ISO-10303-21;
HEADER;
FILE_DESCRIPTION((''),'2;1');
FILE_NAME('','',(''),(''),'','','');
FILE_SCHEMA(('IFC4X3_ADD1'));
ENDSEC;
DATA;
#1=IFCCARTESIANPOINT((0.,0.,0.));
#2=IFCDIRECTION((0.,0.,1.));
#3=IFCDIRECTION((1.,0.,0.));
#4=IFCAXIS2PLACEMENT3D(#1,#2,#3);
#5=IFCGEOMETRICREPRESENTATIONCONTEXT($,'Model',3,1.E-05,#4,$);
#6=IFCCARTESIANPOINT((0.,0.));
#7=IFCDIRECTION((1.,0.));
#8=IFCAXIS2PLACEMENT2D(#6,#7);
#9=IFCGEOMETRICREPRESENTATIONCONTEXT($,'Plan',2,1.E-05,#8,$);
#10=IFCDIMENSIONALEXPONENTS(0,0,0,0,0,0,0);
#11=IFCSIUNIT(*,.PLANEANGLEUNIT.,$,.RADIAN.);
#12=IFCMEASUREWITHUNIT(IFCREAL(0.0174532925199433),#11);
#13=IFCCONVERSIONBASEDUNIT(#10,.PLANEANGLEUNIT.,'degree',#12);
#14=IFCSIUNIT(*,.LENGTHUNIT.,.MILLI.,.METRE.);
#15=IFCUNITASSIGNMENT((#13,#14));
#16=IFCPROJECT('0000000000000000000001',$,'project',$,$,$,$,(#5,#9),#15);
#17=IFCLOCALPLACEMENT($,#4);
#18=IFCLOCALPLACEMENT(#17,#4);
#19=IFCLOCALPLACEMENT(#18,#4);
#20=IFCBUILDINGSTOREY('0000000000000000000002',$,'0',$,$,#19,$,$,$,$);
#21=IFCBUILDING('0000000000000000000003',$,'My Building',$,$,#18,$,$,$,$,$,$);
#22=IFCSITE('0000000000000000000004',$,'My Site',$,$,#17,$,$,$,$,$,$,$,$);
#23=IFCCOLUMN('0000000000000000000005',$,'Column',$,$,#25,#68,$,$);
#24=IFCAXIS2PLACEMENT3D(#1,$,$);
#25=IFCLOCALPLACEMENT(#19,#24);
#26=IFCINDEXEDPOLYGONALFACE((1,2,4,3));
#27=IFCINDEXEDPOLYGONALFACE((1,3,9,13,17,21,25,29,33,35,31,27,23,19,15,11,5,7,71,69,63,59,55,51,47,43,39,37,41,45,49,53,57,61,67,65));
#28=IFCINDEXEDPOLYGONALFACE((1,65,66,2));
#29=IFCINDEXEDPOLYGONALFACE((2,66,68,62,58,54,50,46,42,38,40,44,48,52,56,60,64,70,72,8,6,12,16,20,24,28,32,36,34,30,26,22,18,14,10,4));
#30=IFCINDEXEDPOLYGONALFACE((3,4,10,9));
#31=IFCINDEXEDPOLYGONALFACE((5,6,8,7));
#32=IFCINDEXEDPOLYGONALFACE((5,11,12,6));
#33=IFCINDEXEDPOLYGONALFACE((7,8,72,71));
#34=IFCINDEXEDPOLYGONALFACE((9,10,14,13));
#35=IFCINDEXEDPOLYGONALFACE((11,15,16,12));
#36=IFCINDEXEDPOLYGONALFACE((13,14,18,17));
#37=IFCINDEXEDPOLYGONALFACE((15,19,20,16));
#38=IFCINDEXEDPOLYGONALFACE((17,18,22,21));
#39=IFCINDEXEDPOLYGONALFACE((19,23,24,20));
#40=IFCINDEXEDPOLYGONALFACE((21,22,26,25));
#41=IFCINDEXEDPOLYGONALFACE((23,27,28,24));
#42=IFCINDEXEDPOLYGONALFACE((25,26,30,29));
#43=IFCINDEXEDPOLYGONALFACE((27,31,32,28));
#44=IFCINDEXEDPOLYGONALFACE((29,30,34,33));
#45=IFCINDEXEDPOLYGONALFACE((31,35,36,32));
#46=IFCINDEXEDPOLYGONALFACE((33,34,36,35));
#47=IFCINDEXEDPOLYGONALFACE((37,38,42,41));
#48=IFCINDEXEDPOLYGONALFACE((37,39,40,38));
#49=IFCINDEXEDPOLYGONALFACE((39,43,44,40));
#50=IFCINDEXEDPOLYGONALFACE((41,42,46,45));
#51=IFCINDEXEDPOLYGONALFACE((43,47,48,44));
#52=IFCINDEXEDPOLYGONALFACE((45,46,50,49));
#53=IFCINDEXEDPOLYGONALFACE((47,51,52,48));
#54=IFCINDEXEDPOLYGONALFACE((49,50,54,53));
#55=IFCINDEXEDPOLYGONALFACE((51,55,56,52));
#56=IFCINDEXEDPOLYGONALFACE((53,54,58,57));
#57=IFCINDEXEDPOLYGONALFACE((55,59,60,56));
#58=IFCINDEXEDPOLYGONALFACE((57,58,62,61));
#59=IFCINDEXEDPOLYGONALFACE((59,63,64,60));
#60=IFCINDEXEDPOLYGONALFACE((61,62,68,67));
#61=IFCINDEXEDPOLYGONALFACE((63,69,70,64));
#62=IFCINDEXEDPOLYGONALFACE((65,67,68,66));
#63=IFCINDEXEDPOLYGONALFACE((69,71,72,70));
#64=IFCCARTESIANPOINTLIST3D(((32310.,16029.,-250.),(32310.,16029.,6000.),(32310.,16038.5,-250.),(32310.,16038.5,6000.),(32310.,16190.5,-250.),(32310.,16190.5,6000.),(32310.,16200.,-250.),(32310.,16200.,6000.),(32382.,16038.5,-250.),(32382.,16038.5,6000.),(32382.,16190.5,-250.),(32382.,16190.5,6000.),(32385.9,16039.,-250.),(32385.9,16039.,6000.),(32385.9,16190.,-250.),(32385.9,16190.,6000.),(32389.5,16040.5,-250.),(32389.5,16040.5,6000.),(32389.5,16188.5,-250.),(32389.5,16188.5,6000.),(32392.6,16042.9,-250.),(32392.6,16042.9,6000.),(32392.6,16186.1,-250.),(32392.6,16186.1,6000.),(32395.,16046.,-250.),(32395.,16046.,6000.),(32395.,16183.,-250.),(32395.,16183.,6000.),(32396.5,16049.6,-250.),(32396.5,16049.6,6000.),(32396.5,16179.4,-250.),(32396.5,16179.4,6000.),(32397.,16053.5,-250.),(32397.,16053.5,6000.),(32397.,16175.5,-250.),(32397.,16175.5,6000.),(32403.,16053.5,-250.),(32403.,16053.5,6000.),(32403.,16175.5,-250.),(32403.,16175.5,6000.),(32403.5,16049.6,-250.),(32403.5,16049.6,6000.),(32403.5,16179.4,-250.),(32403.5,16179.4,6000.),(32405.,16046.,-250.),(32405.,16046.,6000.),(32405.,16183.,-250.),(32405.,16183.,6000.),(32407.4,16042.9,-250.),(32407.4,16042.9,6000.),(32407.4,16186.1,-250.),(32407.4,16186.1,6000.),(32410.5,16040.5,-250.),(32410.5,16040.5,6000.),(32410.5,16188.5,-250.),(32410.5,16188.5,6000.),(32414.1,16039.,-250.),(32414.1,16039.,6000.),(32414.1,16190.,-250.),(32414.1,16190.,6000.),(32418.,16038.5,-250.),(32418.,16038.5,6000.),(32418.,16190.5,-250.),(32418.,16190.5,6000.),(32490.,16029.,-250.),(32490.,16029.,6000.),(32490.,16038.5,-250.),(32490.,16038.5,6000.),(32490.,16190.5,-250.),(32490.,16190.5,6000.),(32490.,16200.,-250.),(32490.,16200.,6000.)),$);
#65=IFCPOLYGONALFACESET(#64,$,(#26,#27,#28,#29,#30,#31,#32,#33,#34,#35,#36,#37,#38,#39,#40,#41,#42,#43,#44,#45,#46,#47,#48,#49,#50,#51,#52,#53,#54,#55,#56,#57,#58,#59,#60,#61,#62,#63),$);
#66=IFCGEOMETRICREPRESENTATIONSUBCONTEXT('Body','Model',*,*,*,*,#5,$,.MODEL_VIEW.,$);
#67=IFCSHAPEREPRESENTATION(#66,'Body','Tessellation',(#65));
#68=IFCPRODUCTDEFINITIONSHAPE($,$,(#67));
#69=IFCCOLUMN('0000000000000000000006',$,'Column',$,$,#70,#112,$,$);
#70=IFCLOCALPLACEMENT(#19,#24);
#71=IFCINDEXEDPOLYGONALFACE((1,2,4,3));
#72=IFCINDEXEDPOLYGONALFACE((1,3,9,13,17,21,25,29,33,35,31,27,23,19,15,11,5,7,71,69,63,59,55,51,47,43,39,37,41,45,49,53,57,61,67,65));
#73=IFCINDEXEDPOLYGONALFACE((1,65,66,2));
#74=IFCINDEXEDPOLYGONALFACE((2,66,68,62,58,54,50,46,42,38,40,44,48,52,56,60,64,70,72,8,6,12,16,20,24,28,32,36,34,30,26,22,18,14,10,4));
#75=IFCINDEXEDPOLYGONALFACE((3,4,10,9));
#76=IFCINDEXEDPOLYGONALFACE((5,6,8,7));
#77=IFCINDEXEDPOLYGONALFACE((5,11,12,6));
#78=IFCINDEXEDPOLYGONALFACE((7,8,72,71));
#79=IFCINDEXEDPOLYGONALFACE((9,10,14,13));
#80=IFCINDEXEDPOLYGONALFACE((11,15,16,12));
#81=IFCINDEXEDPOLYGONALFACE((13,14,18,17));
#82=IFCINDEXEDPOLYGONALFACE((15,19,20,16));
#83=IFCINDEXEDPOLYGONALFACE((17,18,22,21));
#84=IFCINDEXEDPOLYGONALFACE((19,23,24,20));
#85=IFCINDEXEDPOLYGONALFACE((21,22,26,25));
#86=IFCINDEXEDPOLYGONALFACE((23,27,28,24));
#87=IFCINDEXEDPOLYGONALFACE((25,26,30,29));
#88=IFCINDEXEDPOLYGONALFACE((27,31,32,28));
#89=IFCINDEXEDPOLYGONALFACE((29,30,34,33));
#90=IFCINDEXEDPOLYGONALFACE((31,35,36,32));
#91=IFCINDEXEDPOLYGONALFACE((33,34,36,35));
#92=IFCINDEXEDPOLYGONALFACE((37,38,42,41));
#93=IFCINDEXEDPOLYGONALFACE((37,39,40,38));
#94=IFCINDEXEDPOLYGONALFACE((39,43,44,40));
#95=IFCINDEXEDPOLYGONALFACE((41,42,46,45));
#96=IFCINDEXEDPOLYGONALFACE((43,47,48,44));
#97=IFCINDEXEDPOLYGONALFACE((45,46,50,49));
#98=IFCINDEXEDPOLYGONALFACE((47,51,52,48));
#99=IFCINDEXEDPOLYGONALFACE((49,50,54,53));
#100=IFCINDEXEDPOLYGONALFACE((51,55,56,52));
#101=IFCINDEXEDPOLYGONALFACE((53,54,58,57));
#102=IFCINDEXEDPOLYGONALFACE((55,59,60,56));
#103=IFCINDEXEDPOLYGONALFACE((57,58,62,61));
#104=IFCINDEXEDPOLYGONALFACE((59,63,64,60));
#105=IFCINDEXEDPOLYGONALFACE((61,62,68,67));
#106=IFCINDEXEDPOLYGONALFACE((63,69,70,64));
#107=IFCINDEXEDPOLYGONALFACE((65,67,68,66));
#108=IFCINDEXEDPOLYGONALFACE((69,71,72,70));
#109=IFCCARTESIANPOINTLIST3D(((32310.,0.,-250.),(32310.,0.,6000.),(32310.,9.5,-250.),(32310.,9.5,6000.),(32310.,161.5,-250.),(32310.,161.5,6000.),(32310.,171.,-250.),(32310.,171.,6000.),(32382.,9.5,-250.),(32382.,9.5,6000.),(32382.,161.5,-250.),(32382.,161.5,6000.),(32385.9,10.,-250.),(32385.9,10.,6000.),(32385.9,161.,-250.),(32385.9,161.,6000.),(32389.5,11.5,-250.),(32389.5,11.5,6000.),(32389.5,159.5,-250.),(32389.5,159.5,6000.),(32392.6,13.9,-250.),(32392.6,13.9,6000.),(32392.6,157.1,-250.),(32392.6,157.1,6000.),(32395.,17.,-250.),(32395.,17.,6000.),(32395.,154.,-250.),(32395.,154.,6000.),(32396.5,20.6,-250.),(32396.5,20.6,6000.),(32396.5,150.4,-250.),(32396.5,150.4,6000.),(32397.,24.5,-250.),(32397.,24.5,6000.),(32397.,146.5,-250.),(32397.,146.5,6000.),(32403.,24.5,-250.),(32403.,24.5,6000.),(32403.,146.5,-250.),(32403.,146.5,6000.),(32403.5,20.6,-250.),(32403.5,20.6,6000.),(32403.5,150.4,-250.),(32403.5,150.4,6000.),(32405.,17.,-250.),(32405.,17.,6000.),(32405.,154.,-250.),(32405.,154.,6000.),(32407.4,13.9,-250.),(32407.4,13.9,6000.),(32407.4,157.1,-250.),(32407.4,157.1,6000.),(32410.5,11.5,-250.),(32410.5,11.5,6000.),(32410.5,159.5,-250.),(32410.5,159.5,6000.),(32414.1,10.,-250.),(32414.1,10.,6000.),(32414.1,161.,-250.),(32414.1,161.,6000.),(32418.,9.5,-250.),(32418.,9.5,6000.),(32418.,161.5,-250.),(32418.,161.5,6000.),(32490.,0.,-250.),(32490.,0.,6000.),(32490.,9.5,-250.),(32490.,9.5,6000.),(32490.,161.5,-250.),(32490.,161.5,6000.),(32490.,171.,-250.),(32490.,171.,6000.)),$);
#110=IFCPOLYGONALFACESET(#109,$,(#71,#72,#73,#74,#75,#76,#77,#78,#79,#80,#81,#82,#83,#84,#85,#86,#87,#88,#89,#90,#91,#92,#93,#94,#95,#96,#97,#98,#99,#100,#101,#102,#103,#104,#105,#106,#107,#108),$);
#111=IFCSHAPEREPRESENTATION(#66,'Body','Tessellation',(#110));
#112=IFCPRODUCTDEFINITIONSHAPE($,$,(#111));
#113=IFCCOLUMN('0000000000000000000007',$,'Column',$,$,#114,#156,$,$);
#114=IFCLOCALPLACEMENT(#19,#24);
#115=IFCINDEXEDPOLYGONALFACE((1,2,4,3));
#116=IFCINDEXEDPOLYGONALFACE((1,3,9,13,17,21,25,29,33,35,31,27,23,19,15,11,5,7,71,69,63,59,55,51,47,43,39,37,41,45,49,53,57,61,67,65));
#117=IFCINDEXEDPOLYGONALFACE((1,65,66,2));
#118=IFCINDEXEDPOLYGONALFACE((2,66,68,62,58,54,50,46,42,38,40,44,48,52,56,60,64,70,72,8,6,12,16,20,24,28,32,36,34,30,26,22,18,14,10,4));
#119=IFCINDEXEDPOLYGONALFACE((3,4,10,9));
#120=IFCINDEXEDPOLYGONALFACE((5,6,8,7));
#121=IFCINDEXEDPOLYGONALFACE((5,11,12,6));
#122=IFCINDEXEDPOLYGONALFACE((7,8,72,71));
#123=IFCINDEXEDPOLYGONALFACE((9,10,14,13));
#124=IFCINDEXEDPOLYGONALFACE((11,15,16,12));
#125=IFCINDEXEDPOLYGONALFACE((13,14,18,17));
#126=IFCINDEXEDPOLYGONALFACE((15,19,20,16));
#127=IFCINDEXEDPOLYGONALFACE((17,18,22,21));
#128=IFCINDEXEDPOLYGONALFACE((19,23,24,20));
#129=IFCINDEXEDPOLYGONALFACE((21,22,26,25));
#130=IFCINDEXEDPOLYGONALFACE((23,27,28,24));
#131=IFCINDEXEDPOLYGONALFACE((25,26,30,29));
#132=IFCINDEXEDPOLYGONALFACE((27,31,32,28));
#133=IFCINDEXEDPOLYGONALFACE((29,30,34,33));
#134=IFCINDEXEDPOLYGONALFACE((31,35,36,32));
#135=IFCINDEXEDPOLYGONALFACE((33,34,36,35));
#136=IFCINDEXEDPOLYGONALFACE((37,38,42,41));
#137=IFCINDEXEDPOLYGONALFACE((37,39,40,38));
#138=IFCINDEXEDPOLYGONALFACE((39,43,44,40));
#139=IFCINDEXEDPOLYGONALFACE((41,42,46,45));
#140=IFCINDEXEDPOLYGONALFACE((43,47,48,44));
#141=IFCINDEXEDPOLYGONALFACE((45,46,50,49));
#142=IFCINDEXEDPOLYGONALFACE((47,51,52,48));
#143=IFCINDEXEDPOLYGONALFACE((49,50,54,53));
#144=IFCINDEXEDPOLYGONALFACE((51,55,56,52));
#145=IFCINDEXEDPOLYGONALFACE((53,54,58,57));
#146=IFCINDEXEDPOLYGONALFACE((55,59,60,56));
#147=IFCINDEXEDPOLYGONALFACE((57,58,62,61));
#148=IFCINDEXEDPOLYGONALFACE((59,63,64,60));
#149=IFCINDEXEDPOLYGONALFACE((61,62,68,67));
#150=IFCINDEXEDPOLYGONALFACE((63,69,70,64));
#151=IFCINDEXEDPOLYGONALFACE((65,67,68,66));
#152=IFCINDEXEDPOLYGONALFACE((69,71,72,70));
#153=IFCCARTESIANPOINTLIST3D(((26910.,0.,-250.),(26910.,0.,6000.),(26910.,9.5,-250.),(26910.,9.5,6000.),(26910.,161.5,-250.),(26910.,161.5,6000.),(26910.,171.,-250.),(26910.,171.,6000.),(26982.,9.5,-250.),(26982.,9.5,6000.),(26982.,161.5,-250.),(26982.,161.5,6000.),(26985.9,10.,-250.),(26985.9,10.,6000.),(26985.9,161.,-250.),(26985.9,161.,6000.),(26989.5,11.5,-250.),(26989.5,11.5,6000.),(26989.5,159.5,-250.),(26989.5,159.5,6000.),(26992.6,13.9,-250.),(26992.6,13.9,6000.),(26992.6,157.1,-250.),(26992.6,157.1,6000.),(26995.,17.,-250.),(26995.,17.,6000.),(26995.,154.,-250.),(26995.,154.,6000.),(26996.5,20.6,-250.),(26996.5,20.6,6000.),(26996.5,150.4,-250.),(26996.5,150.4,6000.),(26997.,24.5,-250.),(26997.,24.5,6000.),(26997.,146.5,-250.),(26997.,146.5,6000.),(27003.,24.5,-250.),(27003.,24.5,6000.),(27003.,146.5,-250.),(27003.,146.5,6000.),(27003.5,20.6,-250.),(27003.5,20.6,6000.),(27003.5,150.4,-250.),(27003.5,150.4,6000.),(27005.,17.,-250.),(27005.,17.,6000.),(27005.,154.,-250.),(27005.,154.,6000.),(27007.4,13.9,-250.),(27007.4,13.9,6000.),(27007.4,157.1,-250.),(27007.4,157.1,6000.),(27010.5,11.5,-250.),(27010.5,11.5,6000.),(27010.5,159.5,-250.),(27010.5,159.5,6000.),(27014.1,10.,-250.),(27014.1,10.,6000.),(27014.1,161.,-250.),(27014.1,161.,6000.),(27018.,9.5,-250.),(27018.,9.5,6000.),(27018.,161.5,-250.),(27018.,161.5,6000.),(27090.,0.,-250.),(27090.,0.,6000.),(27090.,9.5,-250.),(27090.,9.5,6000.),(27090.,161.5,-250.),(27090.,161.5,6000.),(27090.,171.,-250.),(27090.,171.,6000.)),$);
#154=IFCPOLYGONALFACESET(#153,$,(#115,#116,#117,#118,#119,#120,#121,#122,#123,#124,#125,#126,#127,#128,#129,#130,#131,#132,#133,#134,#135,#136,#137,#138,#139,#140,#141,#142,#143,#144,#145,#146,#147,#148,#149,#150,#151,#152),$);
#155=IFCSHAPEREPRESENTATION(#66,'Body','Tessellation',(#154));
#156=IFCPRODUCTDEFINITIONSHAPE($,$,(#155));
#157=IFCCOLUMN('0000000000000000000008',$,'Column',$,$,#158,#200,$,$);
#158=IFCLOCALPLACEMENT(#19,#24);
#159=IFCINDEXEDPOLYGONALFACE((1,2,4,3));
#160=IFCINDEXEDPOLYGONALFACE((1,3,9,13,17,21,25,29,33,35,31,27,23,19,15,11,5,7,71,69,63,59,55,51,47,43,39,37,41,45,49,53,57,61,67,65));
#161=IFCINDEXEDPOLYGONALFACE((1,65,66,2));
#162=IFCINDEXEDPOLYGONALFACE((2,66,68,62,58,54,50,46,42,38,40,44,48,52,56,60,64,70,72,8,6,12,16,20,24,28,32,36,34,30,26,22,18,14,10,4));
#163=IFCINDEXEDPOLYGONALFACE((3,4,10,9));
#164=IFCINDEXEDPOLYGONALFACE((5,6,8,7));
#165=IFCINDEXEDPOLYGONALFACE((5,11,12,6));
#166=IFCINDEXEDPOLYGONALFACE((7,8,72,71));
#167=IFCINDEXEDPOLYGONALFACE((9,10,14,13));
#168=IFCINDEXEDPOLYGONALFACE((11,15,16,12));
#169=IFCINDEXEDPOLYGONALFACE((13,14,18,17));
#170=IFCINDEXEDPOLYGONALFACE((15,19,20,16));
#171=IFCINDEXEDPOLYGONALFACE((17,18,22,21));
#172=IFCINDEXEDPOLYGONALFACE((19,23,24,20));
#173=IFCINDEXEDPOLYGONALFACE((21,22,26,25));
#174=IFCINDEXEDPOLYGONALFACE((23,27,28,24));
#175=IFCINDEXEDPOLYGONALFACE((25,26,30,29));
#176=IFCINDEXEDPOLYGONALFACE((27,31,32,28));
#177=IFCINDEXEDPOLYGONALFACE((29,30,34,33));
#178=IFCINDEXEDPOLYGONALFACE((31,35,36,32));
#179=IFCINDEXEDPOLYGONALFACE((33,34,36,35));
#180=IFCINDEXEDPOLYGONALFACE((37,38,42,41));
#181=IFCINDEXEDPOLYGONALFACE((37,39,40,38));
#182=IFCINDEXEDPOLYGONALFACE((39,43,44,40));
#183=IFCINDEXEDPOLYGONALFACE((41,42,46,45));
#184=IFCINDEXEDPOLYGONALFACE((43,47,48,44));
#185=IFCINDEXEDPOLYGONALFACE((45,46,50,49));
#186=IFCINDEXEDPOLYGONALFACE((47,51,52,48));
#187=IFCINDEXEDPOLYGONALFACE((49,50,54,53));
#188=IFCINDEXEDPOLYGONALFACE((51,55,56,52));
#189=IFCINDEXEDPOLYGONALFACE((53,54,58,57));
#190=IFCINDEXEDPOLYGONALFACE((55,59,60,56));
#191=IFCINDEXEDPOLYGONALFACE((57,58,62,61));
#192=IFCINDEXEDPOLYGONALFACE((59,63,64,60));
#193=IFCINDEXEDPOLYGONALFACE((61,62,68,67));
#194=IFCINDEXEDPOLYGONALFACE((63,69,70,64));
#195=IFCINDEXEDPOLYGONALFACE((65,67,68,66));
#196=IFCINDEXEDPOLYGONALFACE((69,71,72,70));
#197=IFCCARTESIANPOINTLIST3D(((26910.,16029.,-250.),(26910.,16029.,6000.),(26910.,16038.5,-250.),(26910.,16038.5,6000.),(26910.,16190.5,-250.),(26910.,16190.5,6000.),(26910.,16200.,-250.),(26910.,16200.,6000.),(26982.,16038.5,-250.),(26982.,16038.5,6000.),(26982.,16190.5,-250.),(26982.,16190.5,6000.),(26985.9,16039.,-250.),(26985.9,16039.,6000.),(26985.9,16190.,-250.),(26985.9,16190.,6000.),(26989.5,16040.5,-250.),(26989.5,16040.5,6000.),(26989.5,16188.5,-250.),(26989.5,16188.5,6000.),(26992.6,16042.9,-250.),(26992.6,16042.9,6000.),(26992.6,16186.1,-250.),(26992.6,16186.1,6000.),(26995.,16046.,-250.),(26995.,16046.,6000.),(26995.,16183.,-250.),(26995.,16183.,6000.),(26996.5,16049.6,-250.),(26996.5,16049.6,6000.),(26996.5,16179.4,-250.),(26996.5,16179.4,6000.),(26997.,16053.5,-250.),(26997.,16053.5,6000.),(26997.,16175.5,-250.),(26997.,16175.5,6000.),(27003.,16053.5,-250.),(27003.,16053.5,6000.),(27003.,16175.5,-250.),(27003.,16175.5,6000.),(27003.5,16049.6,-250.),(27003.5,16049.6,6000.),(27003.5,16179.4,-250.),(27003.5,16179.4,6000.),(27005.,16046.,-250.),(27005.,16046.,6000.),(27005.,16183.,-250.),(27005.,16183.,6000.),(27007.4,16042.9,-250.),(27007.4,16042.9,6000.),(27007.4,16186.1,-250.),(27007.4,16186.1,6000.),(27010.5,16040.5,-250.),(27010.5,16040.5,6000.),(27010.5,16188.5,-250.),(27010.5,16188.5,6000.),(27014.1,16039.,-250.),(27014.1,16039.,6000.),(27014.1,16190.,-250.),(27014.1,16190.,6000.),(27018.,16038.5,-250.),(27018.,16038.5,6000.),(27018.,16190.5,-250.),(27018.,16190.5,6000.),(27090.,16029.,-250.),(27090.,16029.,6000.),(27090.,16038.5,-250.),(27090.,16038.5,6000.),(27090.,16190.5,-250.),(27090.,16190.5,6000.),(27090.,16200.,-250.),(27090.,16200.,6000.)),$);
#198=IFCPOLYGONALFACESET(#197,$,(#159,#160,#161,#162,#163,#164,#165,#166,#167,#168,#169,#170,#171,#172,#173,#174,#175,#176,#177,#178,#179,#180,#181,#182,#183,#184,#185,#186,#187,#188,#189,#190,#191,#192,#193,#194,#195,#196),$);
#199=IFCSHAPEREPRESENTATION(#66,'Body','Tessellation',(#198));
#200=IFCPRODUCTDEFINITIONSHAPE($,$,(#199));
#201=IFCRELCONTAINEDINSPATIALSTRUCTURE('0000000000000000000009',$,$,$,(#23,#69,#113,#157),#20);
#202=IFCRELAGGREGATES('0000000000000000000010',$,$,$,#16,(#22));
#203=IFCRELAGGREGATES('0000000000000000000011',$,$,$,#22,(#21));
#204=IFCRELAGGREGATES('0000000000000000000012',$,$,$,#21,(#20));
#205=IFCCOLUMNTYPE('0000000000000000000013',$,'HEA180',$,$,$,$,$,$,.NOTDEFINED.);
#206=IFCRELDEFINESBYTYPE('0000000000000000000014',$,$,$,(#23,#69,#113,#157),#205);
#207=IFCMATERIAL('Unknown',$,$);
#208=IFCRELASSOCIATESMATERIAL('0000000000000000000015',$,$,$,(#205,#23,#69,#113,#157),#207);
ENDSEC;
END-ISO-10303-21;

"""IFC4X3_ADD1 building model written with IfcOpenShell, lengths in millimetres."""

from ifc_helpers import new_model, entity, si_unit, converted_unit, frame, origin_with_axes, origin_2d_with_axis, place, context, subcontext, project, spatial, i_section, extrude, material, material_profile, profile_set, profile_usage, type_object, element, save


model = new_model("IFC4X3_ADD1")

# Units and contexts
model_context = context("Model", 3, precision=1e-05, world=origin_with_axes())
plan_context = context("Plan", 2, precision=1e-05, world=origin_2d_with_axis())
body_context = subcontext(model_context, "Body", "Model", "MODEL_VIEW")
ifc_project = project(units=[converted_unit("PLANEANGLEUNIT", "degree", entity("IfcReal", 0.0174532925199433), si_unit("PLANEANGLEUNIT", "RADIAN"), dimensions=[0, 0, 0, 0, 0, 0, 0]), si_unit("LENGTHUNIT", "METRE", prefix="MILLI")], contexts=[model_context, plan_context])

# Site, building, storey
site_placement = place(None, origin_with_axes())
site = spatial("IfcSite", under=ifc_project, at=site_placement, Name="My Site")
building_placement = place(site_placement, origin_with_axes())
building = spatial("IfcBuilding", under=site, at=building_placement, Name="My Building")
storey_placement = place(building_placement, origin_with_axes())
storey = spatial("IfcBuildingStorey", under=building, at=storey_placement, Name="0")

# Columns
ifc_material = material(Name="Unknown")
ifc_material_profile_1 = material_profile(ifc_material, i_section(OverallWidth=180.0, OverallDepth=171.0, WebThickness=6.0, FlangeThickness=9.5, FilletRadius=15.0))
ifc_profile_set_1 = profile_set([ifc_material_profile_1])
ifc_profile_usage_1 = profile_usage(ifc_profile_set_1, cardinal=8)
column_type = type_object("IfcColumnType", Name="HEA180", PredefinedType="NOTDEFINED", material=ifc_profile_set_1)
column_1_placement = place(storey_placement, frame((32400.0, 16200.0, -250.0), z_axis=(0.0, 0.0, 1.0), x_axis=(1.0, 0.0, 0.0)))
element("IfcColumn", 1, at=column_1_placement, inside=storey, type_object=column_type, material=ifc_profile_usage_1, Name="Column", context=body_context, shape_type="SweptSolid", body=[
    extrude(i_section(OverallWidth=180.0, OverallDepth=171.0, WebThickness=6.0, FlangeThickness=9.5, FilletRadius=15.0), frame((0.0, -85.5, 0.0), z_axis=(0.0, 0.0, 1.0), x_axis=(1.0, 0.0, 0.0)), (0.0, 0.0, 1.0), 6250.0),
])
ifc_profile_usage_2 = profile_usage(ifc_profile_set_1, cardinal=2)
column_2_placement = place(storey_placement, frame((32400.0, 0.0, -250.0), z_axis=(0.0, 0.0, 1.0), x_axis=(1.0, 0.0, 0.0)))
element("IfcColumn", 2, at=column_2_placement, inside=storey, type_object=column_type, material=ifc_profile_usage_2, Name="Column", context=body_context, shape_type="SweptSolid", body=[
    extrude(i_section(OverallWidth=180.0, OverallDepth=171.0, WebThickness=6.0, FlangeThickness=9.5, FilletRadius=15.0), frame((0.0, 85.5, 0.0), z_axis=(0.0, 0.0, 1.0), x_axis=(1.0, 0.0, 0.0)), (0.0, 0.0, 1.0), 6250.0),
])
ifc_profile_usage_3 = profile_usage(ifc_profile_set_1, cardinal=2)
column_3_placement = place(storey_placement, frame((27000.0, 0.0, -250.0), z_axis=(0.0, 0.0, 1.0), x_axis=(1.0, 0.0, 0.0)))
element("IfcColumn", 3, at=column_3_placement, inside=storey, type_object=column_type, material=ifc_profile_usage_3, Name="Column", context=body_context, shape_type="SweptSolid", body=[
    extrude(i_section(OverallWidth=180.0, OverallDepth=171.0, WebThickness=6.0, FlangeThickness=9.5, FilletRadius=15.0), frame((0.0, 85.5, 0.0), z_axis=(0.0, 0.0, 1.0), x_axis=(1.0, 0.0, 0.0)), (0.0, 0.0, 1.0), 6250.0),
])
ifc_profile_usage_4 = profile_usage(ifc_profile_set_1, cardinal=8)
column_4_placement = place(storey_placement, frame((27000.0, 16200.0, -250.0), z_axis=(0.0, 0.0, 1.0), x_axis=(1.0, 0.0, 0.0)))
element("IfcColumn", 4, at=column_4_placement, inside=storey, type_object=column_type, material=ifc_profile_usage_4, Name="Column", context=body_context, shape_type="SweptSolid", body=[
    extrude(i_section(OverallWidth=180.0, OverallDepth=171.0, WebThickness=6.0, FlangeThickness=9.5, FilletRadius=15.0), frame((0.0, -85.5, 0.0), z_axis=(0.0, 0.0, 1.0), x_axis=(1.0, 0.0, 0.0)), (0.0, 0.0, 1.0), 6250.0),
])

save(model, "model.ifc")
